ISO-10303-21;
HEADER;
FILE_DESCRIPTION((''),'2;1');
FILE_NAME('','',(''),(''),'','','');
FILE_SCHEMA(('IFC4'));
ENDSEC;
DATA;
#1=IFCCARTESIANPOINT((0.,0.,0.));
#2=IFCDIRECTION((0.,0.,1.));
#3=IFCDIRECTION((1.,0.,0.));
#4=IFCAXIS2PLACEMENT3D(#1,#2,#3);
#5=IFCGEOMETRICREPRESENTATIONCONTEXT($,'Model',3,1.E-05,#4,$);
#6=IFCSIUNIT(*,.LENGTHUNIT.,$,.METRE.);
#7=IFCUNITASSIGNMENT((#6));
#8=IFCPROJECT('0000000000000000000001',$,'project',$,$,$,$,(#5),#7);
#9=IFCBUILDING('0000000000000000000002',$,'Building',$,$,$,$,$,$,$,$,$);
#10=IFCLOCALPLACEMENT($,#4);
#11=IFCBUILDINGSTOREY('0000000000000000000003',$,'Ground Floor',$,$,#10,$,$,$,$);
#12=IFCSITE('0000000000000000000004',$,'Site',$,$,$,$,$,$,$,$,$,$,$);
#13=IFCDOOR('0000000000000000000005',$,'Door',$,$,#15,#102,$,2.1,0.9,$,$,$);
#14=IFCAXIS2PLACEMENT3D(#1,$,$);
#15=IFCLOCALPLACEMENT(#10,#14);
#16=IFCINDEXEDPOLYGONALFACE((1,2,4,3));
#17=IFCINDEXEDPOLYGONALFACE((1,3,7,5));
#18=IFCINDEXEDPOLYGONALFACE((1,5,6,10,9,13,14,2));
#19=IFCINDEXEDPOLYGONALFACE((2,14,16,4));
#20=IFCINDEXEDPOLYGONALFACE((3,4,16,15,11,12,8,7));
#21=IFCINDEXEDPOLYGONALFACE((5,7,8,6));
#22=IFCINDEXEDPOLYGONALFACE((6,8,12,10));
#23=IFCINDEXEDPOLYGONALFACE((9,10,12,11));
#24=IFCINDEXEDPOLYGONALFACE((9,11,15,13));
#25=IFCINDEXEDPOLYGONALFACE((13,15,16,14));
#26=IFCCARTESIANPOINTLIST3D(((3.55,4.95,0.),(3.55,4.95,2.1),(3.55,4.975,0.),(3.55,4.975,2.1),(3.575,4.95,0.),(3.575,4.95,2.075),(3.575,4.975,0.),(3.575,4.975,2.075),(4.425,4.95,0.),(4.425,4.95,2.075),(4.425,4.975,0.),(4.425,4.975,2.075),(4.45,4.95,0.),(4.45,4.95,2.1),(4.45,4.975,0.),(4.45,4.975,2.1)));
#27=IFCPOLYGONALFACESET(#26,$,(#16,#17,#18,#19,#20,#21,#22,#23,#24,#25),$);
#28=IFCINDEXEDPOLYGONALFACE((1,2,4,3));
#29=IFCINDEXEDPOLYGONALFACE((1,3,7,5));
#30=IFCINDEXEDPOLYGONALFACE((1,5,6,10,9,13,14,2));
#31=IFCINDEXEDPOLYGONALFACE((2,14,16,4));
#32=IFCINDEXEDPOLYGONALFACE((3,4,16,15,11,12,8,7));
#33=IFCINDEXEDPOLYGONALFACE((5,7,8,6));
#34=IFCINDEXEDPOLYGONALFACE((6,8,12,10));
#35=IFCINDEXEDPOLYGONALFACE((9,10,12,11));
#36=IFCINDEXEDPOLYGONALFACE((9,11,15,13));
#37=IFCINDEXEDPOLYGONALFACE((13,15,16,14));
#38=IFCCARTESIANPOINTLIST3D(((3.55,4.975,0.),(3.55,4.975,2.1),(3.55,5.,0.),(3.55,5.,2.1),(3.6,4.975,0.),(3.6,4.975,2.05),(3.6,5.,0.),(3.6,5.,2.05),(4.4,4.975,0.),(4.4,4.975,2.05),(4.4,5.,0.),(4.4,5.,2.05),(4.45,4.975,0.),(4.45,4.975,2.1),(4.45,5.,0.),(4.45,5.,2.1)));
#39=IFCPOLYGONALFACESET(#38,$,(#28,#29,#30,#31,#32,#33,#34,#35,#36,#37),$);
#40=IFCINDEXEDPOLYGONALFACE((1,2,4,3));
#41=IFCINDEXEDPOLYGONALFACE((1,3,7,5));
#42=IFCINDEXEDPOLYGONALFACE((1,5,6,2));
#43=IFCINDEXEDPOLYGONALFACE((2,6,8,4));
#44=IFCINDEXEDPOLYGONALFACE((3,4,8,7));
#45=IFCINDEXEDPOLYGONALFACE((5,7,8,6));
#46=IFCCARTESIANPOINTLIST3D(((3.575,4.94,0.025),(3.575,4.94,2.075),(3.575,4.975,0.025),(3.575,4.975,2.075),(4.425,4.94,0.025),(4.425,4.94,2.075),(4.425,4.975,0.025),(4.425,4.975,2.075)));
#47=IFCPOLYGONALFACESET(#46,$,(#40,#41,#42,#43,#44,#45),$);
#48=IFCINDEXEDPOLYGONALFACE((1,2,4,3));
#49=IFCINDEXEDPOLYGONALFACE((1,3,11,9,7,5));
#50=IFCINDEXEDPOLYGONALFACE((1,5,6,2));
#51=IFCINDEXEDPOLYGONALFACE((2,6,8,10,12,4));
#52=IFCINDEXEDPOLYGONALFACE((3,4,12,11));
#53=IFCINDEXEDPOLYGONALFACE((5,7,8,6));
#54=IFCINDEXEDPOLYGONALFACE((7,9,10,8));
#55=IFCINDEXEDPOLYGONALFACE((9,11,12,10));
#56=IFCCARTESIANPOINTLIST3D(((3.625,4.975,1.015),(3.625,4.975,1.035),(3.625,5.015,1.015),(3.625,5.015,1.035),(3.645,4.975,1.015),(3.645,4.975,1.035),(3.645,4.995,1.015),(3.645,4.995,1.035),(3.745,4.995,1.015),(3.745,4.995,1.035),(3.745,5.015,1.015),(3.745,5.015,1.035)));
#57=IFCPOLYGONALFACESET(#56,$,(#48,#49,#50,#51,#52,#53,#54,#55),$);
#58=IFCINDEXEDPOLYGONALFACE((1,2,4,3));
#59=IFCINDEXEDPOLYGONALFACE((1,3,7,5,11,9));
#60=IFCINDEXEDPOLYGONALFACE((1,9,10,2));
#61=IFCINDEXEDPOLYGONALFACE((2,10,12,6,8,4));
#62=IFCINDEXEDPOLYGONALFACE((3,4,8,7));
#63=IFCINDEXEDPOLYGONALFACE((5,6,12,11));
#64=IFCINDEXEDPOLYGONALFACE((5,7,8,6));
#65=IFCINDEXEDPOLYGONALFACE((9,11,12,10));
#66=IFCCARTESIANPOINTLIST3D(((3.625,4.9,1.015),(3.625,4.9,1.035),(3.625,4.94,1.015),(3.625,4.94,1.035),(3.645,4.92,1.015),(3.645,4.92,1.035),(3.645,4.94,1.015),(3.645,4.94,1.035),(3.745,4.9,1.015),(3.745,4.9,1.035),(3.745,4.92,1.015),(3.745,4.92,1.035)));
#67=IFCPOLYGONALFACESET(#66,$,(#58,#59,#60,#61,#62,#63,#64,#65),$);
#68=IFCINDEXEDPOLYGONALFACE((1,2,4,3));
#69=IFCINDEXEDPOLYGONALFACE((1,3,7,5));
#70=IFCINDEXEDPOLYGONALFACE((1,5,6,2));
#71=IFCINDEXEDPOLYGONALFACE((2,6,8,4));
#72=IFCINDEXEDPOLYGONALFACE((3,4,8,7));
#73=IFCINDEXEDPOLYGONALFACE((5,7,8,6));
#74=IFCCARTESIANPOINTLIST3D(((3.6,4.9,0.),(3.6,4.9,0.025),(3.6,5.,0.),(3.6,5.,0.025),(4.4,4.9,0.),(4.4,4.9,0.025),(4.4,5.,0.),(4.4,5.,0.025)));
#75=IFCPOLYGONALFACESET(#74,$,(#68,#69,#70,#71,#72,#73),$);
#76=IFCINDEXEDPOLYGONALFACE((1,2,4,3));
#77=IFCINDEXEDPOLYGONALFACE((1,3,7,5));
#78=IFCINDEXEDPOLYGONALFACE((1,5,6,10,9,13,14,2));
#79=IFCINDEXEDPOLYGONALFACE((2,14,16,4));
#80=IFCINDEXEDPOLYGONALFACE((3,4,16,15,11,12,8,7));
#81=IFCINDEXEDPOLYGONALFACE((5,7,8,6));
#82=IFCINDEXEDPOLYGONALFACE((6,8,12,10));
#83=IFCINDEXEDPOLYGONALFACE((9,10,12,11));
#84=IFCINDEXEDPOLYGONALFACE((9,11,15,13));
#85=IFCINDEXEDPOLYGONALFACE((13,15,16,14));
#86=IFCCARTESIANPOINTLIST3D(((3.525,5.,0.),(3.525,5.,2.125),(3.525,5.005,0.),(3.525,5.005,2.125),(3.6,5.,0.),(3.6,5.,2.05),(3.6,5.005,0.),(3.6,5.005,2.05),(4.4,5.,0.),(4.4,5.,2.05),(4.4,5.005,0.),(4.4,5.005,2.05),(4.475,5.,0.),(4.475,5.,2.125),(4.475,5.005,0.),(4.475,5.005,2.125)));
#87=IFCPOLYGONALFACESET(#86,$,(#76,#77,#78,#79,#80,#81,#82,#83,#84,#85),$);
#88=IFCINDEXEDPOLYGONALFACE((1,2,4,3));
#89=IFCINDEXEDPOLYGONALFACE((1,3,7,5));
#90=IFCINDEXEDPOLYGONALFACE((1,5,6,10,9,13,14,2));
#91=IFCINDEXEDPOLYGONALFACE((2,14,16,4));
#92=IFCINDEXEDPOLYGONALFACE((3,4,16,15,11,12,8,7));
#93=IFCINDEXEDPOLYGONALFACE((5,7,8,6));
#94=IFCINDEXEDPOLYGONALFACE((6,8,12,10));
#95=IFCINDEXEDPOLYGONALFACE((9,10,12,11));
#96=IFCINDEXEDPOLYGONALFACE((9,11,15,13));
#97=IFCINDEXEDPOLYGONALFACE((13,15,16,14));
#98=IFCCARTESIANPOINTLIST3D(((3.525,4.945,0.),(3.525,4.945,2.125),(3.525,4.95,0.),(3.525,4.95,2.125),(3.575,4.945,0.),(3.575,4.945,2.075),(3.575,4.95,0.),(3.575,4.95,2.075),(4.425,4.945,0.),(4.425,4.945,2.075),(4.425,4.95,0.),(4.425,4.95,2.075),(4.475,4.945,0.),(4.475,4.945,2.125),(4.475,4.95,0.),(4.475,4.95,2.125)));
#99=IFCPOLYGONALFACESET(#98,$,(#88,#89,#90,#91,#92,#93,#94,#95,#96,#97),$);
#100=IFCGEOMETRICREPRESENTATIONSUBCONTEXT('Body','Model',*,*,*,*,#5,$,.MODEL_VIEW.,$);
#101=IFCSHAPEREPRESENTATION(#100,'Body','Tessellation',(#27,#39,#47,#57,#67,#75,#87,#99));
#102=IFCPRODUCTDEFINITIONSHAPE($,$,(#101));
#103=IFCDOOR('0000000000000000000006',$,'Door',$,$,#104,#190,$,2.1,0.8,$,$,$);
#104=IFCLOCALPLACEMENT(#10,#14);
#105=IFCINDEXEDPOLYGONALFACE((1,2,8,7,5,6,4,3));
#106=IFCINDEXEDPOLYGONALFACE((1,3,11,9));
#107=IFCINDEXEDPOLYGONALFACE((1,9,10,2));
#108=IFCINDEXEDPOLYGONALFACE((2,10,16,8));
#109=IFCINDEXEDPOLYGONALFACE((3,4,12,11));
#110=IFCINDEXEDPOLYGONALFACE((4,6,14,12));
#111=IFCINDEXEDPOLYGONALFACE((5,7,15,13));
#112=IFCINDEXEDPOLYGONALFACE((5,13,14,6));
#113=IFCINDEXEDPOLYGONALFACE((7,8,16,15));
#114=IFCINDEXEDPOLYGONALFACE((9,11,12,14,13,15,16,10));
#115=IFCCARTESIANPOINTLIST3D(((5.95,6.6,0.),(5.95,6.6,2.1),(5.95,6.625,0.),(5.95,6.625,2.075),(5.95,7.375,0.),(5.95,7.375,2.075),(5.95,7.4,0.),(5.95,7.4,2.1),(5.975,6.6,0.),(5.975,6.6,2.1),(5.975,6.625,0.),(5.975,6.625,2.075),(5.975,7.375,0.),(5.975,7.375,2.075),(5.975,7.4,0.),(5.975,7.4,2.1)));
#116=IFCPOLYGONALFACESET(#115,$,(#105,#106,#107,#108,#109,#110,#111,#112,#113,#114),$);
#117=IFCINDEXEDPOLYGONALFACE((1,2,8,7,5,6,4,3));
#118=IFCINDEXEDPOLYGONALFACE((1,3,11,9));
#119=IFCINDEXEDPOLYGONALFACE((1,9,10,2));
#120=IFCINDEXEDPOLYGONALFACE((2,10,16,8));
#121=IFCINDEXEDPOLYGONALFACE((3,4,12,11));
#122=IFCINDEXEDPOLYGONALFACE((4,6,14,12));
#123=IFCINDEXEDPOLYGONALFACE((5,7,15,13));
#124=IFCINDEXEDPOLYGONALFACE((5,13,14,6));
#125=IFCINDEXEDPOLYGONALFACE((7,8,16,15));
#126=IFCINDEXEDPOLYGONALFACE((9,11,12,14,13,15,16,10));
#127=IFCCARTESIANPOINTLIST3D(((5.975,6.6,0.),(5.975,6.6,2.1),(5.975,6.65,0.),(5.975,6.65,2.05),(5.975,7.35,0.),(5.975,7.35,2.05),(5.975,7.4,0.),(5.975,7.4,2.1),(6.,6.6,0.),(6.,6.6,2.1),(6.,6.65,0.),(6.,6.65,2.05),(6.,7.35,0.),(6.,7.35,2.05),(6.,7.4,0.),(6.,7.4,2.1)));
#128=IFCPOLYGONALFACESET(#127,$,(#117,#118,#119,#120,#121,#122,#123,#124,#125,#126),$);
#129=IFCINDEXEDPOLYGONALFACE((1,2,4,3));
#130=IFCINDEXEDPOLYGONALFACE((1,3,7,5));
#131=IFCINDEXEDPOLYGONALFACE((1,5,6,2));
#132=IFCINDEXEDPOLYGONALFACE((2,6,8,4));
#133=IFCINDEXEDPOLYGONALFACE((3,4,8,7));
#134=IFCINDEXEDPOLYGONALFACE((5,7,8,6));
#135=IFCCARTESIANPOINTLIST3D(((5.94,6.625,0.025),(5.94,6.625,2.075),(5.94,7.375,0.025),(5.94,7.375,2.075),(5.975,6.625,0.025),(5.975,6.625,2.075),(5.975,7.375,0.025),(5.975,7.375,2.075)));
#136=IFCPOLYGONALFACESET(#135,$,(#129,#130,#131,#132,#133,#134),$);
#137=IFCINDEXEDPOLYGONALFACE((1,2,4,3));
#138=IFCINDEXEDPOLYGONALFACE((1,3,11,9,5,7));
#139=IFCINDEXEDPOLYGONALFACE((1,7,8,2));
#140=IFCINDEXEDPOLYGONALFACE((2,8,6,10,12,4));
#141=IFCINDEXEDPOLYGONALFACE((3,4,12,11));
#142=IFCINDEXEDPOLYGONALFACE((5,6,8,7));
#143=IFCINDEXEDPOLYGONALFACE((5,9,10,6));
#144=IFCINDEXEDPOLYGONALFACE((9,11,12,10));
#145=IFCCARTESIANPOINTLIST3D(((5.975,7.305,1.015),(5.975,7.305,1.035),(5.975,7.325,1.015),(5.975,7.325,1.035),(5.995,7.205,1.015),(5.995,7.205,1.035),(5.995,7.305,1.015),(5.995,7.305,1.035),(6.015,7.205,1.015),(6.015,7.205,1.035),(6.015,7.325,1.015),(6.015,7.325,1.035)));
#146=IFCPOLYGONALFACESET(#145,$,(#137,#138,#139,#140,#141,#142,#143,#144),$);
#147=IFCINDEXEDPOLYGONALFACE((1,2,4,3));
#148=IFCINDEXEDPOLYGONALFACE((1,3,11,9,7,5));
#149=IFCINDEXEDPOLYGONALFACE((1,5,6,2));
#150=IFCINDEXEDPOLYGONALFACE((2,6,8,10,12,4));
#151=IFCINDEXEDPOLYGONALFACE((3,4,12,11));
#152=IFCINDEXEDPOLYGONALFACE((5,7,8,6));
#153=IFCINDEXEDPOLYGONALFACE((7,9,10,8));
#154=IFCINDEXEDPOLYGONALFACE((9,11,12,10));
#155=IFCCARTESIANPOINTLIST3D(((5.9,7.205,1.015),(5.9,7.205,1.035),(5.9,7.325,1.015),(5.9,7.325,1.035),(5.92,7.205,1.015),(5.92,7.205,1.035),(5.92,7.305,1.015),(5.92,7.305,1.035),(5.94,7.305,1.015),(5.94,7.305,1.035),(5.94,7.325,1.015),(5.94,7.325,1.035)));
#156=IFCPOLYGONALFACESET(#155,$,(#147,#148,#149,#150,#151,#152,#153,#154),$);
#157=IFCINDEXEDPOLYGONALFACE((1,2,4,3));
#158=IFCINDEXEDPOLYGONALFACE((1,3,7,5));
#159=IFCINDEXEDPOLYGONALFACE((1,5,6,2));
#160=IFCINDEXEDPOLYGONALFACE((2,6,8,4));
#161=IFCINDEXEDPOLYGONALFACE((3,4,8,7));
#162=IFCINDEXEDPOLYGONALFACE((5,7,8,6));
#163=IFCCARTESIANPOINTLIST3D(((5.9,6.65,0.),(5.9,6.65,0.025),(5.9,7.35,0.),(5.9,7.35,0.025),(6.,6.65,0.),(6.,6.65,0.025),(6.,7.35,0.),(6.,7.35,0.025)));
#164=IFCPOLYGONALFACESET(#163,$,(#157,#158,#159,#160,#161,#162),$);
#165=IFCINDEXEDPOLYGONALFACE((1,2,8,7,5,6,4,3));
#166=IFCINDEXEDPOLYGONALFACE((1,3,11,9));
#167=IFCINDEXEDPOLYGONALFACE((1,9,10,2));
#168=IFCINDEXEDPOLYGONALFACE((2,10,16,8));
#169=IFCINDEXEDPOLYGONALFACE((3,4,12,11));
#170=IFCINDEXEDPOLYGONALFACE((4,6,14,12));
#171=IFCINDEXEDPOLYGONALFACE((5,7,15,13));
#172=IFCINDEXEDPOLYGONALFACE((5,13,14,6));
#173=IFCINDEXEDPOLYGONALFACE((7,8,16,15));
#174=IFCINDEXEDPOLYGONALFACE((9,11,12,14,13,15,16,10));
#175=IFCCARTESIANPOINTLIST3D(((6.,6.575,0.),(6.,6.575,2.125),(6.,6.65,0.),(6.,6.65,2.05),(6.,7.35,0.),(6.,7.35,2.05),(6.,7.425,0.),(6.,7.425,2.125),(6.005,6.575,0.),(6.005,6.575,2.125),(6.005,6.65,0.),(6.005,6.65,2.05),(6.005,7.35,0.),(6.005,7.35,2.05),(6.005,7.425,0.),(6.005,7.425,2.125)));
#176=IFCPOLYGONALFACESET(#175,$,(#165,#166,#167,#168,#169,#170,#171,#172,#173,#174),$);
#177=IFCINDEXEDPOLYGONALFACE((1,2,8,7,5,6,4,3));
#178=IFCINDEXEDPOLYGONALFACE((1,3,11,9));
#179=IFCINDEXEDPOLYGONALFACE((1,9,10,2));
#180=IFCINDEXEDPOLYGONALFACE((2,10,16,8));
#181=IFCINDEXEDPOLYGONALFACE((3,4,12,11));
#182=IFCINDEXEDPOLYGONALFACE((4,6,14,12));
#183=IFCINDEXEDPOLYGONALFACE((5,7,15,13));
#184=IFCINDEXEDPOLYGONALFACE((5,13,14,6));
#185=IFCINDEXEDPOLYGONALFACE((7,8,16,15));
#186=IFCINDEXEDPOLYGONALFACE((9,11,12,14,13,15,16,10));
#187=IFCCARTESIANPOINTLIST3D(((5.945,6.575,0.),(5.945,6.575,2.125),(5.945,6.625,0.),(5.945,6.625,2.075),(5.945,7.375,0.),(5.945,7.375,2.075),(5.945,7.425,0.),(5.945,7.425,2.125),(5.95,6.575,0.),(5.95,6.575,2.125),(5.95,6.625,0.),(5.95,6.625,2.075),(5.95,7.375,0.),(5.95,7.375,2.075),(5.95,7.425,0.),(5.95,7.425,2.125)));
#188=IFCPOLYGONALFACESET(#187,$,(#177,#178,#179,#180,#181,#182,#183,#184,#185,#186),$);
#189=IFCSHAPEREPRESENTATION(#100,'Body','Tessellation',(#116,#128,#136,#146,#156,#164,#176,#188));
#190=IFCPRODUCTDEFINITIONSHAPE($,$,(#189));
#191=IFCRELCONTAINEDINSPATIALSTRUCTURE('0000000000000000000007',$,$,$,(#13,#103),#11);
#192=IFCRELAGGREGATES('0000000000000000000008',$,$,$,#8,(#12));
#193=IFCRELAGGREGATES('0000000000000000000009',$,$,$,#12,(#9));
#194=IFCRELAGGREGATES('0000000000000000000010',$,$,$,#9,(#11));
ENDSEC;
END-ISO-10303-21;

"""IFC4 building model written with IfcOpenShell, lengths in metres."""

from ifc_helpers import new_model, si_unit, frame, origin_with_axes, place, context, subcontext, project, spatial, line, indexed_curve, outline, extrude, element, save


model = new_model("IFC4")

# Units and contexts
model_context = context("Model", 3, precision=1e-05, world=origin_with_axes())
body_context = subcontext(model_context, "Body", "Model", "MODEL_VIEW")
ifc_project = project(units=[si_unit("LENGTHUNIT", "METRE")], contexts=[model_context])

# Site, building, storey
site = spatial("IfcSite", under=ifc_project, Name="Site")
building = spatial("IfcBuilding", under=site, Name="Building")
storey_placement = place(None, origin_with_axes())
storey = spatial("IfcBuildingStorey", under=building, at=storey_placement, Name="Ground Floor")

# Doors
door_1_placement = place(storey_placement, frame((4.45, 5.0, 0.0), z_axis=(0.0, 0.0, 1.0), x_axis=(-1.0, 0.0, 0.0)))
element("IfcDoor", 1, at=door_1_placement, inside=storey, Name="Door", OverallHeight=2.1, OverallWidth=0.9, context=body_context, shape_type="SweptSolid", body=[
    extrude(outline(indexed_curve([(0.0, 0.0), (0.0, 2.1), (0.9, 2.1), (0.9, 0.0), (0.875, 0.0), (0.875, 2.075), (0.025, 2.075), (0.025, 0.0)], segments=[line(1, 2, 3, 4, 5, 6, 7, 8, 1)])), frame((0.0, 0.025, 0.0), z_axis=(0.0, -1.0, 0.0), x_axis=(1.0, 0.0, 0.0)), (0.0, 0.0, -1.0), 0.025),
    extrude(outline(indexed_curve([(0.0, 0.0), (0.0, 2.1), (0.9, 2.1), (0.9, 0.0), (0.85, 0.0), (0.85, 2.05), (0.05, 2.05), (0.05, 0.0)], segments=[line(1, 2, 3, 4, 5, 6, 7, 8, 1)])), frame((0.0, 0.0, 0.0), z_axis=(0.0, -1.0, 0.0), x_axis=(1.0, 0.0, 0.0)), (0.0, 0.0, -1.0), 0.025),
    extrude(outline(indexed_curve([(0.0, 0.0), (0.85, 0.0), (0.85, 0.035), (0.0, 0.035)], segments=[line(1, 2, 3, 4, 1)])), frame((0.025, 0.025, 0.025), z_axis=(0.0, 0.0, 1.0), x_axis=(1.0, 0.0, 0.0)), (0.0, 0.0, 1.0), 2.05),
    extrude(outline(indexed_curve([(0.0, 0.0), (0.0, -0.04), (-0.12, -0.04), (-0.12, -0.02), (-0.02, -0.02), (-0.02, 0.0)], segments=[line(1, 2, 3, 4, 5, 6, 1)])), frame((0.825, 0.025, 1.015), z_axis=(0.0, 0.0, 1.0), x_axis=(1.0, 0.0, 0.0)), (0.0, 0.0, 1.0), 0.02),
    extrude(outline(indexed_curve([(0.0, 0.0), (0.0, 0.04), (-0.12, 0.04), (-0.12, 0.02), (-0.02, 0.02), (-0.02, 0.0)], segments=[line(1, 2, 3, 4, 5, 6, 1)])), frame((0.825, 0.06, 1.015), z_axis=(0.0, 0.0, 1.0), x_axis=(1.0, 0.0, 0.0)), (0.0, 0.0, 1.0), 0.02),
    extrude(outline(indexed_curve([(0.0, 0.0), (0.8, 0.0), (0.8, 0.1), (0.0, 0.1)], segments=[line(1, 2, 3, 4, 1)])), frame((0.05, 0.0, 0.0), z_axis=(0.0, 0.0, 1.0), x_axis=(1.0, 0.0, 0.0)), (0.0, 0.0, 1.0), 0.025),
    extrude(outline(indexed_curve([(0.0, 0.0), (0.0, 2.125), (0.95, 2.125), (0.95, 0.0), (0.875, 0.0), (0.875, 2.05), (0.075, 2.05), (0.075, 0.0)], segments=[line(1, 2, 3, 4, 5, 6, 7, 8, 1)])), frame((-0.025, -0.005, 0.0), z_axis=(0.0, -1.0, 0.0), x_axis=(1.0, 0.0, 0.0)), (0.0, 0.0, -1.0), 0.005),
    extrude(outline(indexed_curve([(0.0, 0.0), (0.0, 2.125), (0.95, 2.125), (0.95, 0.0), (0.9, 0.0), (0.9, 2.075), (0.05, 2.075), (0.05, 0.0)], segments=[line(1, 2, 3, 4, 5, 6, 7, 8, 1)])), frame((-0.025, 0.05, 0.0), z_axis=(0.0, -1.0, 0.0), x_axis=(1.0, 0.0, 0.0)), (0.0, 0.0, -1.0), 0.005),
])
door_2_placement = place(storey_placement, frame((6.0, 6.6, 0.0), z_axis=(0.0, 0.0, 1.0), x_axis=(0.0, 1.0, 0.0)))
element("IfcDoor", 2, at=door_2_placement, inside=storey, Name="Door", OverallHeight=2.1, OverallWidth=0.8, context=body_context, shape_type="SweptSolid", body=[
    extrude(outline(indexed_curve([(0.0, 0.0), (0.0, 2.1), (0.8, 2.1), (0.8, 0.0), (0.775, 0.0), (0.775, 2.075), (0.025, 2.075), (0.025, 0.0)], segments=[line(1, 2, 3, 4, 5, 6, 7, 8, 1)])), frame((0.0, 0.025, 0.0), z_axis=(0.0, -1.0, 0.0), x_axis=(1.0, 0.0, 0.0)), (0.0, 0.0, -1.0), 0.025),
    extrude(outline(indexed_curve([(0.0, 0.0), (0.0, 2.1), (0.8, 2.1), (0.8, 0.0), (0.75, 0.0), (0.75, 2.05), (0.05, 2.05), (0.05, 0.0)], segments=[line(1, 2, 3, 4, 5, 6, 7, 8, 1)])), frame((0.0, 0.0, 0.0), z_axis=(0.0, -1.0, 0.0), x_axis=(1.0, 0.0, 0.0)), (0.0, 0.0, -1.0), 0.025),
    extrude(outline(indexed_curve([(0.0, 0.0), (0.75, 0.0), (0.75, 0.035), (0.0, 0.035)], segments=[line(1, 2, 3, 4, 1)])), frame((0.025, 0.025, 0.025), z_axis=(0.0, 0.0, 1.0), x_axis=(1.0, 0.0, 0.0)), (0.0, 0.0, 1.0), 2.05),
    extrude(outline(indexed_curve([(0.0, 0.0), (0.0, -0.04), (-0.12, -0.04), (-0.12, -0.02), (-0.02, -0.02), (-0.02, 0.0)], segments=[line(1, 2, 3, 4, 5, 6, 1)])), frame((0.725, 0.025, 1.015), z_axis=(0.0, 0.0, 1.0), x_axis=(1.0, 0.0, 0.0)), (0.0, 0.0, 1.0), 0.02),
    extrude(outline(indexed_curve([(0.0, 0.0), (0.0, 0.04), (-0.12, 0.04), (-0.12, 0.02), (-0.02, 0.02), (-0.02, 0.0)], segments=[line(1, 2, 3, 4, 5, 6, 1)])), frame((0.725, 0.06, 1.015), z_axis=(0.0, 0.0, 1.0), x_axis=(1.0, 0.0, 0.0)), (0.0, 0.0, 1.0), 0.02),
    extrude(outline(indexed_curve([(0.0, 0.0), (0.7, 0.0), (0.7, 0.1), (0.0, 0.1)], segments=[line(1, 2, 3, 4, 1)])), frame((0.05, 0.0, 0.0), z_axis=(0.0, 0.0, 1.0), x_axis=(1.0, 0.0, 0.0)), (0.0, 0.0, 1.0), 0.025),
    extrude(outline(indexed_curve([(0.0, 0.0), (0.0, 2.125), (0.85, 2.125), (0.85, 0.0), (0.775, 0.0), (0.775, 2.05), (0.075, 2.05), (0.075, 0.0)], segments=[line(1, 2, 3, 4, 5, 6, 7, 8, 1)])), frame((-0.025, -0.005, 0.0), z_axis=(0.0, -1.0, 0.0), x_axis=(1.0, 0.0, 0.0)), (0.0, 0.0, -1.0), 0.005),
    extrude(outline(indexed_curve([(0.0, 0.0), (0.0, 2.125), (0.85, 2.125), (0.85, 0.0), (0.8, 0.0), (0.8, 2.075), (0.05, 2.075), (0.05, 0.0)], segments=[line(1, 2, 3, 4, 5, 6, 7, 8, 1)])), frame((-0.025, 0.05, 0.0), z_axis=(0.0, -1.0, 0.0), x_axis=(1.0, 0.0, 0.0)), (0.0, 0.0, -1.0), 0.005),
])

save(model, "model.ifc")
